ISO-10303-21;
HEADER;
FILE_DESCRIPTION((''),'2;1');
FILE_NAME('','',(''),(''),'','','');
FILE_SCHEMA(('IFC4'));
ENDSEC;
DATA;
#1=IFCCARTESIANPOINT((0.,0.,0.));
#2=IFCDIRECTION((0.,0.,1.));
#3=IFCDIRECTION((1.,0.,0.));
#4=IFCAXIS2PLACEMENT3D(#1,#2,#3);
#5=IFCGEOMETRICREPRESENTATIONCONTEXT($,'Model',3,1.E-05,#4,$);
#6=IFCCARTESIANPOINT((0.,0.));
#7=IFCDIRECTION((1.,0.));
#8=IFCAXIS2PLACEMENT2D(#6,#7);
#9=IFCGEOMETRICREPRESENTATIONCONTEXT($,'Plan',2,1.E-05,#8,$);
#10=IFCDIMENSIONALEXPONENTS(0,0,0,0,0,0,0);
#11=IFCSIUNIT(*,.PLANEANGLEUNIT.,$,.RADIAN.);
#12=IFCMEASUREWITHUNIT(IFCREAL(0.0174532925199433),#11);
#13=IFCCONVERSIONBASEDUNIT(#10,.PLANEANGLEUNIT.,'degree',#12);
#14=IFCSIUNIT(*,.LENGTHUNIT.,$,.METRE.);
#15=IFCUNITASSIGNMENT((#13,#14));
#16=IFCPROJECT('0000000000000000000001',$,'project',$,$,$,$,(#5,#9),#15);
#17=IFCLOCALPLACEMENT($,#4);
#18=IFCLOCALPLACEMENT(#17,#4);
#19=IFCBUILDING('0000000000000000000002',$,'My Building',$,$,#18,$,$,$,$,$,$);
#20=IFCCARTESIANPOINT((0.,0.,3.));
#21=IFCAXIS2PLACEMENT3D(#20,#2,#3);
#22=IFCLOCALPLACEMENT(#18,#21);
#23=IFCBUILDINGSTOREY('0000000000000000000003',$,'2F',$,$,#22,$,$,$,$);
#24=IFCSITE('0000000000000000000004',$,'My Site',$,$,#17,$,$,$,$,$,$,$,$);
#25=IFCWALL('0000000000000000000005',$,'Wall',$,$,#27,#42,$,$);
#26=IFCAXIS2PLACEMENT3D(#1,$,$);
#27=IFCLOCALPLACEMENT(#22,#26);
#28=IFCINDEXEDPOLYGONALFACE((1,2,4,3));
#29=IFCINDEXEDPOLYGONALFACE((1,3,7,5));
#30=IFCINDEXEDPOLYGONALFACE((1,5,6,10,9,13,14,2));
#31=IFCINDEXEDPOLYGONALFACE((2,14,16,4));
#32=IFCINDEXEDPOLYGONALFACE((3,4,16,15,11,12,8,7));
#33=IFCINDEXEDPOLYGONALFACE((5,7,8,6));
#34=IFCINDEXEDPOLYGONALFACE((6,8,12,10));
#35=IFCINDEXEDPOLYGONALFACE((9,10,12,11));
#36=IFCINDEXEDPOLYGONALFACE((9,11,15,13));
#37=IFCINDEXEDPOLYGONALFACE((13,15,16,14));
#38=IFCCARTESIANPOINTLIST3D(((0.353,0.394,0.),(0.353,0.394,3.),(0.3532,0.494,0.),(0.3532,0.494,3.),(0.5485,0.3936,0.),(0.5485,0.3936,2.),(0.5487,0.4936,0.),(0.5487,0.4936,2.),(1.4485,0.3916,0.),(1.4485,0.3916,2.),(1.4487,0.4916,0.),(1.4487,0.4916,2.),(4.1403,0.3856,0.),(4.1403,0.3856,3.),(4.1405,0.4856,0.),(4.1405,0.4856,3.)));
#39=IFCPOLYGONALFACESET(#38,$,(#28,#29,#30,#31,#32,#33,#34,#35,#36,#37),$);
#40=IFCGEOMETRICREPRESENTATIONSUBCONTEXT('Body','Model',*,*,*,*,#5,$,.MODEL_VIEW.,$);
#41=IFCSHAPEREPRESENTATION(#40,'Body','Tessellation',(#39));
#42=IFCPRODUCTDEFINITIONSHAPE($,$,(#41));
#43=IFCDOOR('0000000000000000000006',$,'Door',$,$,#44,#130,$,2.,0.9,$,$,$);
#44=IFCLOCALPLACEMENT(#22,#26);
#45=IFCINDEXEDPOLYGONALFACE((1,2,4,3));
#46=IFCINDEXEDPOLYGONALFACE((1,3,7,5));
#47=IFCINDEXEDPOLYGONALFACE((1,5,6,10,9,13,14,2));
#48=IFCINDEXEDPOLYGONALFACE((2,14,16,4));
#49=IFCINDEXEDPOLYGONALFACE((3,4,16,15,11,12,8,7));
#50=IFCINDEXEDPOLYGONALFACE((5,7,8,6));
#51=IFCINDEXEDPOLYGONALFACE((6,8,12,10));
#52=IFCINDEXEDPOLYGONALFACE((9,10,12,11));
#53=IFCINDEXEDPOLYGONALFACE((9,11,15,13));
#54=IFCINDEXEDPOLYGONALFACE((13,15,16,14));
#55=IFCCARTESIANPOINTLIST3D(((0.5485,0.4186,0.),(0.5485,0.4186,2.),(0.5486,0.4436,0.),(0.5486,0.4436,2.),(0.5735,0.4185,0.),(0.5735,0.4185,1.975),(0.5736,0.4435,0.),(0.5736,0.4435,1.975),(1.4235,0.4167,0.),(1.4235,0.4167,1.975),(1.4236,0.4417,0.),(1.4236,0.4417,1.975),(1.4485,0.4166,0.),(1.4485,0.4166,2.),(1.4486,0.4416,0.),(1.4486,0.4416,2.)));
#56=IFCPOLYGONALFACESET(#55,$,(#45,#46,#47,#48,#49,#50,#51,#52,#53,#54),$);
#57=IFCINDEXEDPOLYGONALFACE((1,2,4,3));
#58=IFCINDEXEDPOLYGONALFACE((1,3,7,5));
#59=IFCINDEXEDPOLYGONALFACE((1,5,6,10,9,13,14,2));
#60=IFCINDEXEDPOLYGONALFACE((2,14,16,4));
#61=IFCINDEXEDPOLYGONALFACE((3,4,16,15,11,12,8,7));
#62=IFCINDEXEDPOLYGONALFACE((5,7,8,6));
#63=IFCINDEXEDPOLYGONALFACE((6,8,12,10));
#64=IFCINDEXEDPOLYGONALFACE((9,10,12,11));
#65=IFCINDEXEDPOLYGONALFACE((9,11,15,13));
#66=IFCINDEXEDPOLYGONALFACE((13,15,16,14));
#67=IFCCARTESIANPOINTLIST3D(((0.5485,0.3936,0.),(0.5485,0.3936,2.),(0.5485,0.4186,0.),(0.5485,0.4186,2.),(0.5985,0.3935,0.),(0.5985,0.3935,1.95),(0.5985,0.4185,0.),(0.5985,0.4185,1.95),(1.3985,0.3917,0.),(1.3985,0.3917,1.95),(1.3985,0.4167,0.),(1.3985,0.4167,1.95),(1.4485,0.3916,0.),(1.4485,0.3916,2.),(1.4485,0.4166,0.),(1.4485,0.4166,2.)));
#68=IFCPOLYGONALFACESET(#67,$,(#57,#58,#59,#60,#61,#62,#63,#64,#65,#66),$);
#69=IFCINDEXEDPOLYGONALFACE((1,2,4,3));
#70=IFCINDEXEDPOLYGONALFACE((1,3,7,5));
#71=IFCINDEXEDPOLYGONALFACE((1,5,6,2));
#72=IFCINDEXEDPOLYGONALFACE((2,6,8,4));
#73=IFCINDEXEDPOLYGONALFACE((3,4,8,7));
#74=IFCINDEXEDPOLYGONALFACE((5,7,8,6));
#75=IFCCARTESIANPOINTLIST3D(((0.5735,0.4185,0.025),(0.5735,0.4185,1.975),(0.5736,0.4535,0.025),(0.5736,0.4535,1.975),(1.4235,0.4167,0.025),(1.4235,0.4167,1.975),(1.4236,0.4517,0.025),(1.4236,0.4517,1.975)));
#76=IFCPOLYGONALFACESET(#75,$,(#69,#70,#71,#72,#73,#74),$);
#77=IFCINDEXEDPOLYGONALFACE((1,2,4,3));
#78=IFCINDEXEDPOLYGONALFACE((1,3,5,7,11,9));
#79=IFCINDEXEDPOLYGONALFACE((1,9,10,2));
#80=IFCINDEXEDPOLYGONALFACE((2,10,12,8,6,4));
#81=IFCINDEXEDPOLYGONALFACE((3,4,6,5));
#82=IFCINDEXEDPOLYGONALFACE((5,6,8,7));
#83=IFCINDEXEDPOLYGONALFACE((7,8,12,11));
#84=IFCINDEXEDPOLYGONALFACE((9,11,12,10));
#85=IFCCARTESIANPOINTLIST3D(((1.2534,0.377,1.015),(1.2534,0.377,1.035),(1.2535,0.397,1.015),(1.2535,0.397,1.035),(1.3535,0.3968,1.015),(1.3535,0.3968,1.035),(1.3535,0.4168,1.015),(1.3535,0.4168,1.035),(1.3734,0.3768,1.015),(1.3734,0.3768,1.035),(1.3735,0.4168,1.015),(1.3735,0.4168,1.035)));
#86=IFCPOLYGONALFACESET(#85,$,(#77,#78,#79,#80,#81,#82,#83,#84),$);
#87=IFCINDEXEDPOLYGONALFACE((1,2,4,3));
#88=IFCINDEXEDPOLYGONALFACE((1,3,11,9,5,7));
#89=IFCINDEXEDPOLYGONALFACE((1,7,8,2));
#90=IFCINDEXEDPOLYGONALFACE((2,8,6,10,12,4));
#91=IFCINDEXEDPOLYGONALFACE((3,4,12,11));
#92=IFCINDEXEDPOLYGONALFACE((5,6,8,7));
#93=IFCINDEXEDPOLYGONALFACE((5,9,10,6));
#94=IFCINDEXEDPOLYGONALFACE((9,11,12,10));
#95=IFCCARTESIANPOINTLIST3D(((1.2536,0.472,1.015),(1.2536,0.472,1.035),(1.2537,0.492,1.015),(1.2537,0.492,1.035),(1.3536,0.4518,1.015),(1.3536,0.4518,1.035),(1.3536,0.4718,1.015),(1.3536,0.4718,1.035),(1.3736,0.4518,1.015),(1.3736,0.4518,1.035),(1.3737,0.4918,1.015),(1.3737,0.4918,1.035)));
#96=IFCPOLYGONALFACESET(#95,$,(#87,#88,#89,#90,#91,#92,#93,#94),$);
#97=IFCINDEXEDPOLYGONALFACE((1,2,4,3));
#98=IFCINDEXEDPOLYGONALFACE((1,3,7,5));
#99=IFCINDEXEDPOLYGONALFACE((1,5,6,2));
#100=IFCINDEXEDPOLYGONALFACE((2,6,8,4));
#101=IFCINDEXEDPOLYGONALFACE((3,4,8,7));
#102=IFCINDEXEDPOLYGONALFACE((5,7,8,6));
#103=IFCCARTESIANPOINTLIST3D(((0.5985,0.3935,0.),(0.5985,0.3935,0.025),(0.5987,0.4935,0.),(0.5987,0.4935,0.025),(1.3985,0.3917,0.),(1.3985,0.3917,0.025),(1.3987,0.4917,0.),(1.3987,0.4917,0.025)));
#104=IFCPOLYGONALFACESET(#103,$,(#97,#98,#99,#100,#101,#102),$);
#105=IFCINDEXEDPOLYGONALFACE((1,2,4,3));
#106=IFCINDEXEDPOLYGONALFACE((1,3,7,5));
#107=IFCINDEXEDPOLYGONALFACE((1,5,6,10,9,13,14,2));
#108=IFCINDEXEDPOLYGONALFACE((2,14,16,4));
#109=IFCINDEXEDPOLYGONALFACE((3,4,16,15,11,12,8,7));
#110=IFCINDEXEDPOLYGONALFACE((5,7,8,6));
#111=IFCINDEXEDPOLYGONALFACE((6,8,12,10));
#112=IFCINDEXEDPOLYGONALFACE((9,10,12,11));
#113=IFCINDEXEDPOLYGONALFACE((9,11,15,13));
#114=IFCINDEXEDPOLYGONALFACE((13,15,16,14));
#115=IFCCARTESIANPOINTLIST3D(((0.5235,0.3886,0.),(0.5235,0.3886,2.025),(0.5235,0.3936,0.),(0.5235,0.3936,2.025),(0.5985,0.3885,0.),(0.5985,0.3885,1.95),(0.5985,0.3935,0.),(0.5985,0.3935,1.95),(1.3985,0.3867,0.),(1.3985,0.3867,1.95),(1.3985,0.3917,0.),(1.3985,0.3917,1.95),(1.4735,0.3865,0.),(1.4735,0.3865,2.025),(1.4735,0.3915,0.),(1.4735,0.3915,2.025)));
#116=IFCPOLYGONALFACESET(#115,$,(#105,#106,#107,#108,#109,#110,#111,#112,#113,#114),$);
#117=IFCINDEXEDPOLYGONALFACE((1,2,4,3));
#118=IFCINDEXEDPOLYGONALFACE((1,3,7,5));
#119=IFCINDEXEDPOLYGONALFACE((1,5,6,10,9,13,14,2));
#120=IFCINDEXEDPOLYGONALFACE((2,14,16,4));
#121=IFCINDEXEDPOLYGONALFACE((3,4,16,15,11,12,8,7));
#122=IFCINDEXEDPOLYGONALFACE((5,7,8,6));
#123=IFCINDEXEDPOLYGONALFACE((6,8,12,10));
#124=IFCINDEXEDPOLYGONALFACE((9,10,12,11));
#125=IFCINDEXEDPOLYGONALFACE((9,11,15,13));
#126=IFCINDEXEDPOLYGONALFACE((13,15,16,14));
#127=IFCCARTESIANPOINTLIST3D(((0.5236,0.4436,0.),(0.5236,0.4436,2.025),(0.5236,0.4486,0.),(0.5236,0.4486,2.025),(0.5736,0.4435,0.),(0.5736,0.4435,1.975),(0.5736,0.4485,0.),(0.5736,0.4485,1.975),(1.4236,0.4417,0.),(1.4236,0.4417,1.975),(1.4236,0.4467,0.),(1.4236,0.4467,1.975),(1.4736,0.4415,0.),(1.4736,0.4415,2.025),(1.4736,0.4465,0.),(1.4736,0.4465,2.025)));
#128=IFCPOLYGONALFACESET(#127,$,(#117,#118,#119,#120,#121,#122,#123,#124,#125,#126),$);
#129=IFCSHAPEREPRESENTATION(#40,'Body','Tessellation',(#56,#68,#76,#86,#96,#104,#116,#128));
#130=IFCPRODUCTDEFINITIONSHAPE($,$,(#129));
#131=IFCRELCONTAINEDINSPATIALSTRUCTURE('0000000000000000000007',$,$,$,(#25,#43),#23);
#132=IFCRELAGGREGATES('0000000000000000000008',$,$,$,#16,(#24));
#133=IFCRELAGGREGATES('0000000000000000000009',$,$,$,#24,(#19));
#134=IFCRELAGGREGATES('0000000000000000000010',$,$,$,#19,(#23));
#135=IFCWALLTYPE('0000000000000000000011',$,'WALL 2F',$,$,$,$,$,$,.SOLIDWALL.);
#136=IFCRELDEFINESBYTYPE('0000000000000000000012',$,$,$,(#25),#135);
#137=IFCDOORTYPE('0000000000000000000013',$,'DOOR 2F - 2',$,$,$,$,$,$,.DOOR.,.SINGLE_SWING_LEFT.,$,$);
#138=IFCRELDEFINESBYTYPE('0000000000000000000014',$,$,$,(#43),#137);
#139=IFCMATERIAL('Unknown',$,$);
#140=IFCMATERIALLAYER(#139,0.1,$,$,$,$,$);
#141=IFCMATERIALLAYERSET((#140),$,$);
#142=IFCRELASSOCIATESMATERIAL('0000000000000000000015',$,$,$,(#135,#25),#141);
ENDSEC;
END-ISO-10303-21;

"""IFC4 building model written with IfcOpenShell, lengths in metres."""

from ifc_helpers import new_model, entity, si_unit, converted_unit, frame, origin_with_axes, origin_2d_with_axis, place, context, subcontext, project, spatial, line, indexed_curve, outline, extrude, shape, source, transform, mapped, material, layer, layer_set, layer_usage, type_object, type_shapes, element, fill, save


model = new_model("IFC4")

# Units and contexts
model_context = context("Model", 3, precision=1e-05, world=origin_with_axes())
plan_context = context("Plan", 2, precision=1e-05, world=origin_2d_with_axis())
body_context_1 = subcontext(model_context, "Body", "Model", "MODEL_VIEW")
body_context_2 = subcontext(plan_context, "Body", "Plan", "PLAN_VIEW")
ifc_project = project(units=[converted_unit("PLANEANGLEUNIT", "degree", entity("IfcReal", 0.0174532925199433), si_unit("PLANEANGLEUNIT", "RADIAN"), dimensions=[0, 0, 0, 0, 0, 0, 0]), si_unit("LENGTHUNIT", "METRE")], contexts=[model_context, plan_context])

# Site, building, storey
site_placement = place(None, origin_with_axes())
site = spatial("IfcSite", under=ifc_project, at=site_placement, Name="My Site")
building_placement = place(site_placement, origin_with_axes())
building = spatial("IfcBuilding", under=site, at=building_placement, Name="My Building")
storey_placement = place(building_placement, frame((0.0, 0.0, 3.0), z_axis=(0.0, 0.0, 1.0), x_axis=(1.0, 0.0, 0.0)))
storey = spatial("IfcBuildingStorey", under=building, at=storey_placement, Name="2F")

# Shared definitions
ifc_material = material(Name="Unknown")
ifc_layer = layer(ifc_material, 0.1)
ifc_layer_set = layer_set([ifc_layer])
wall_type = type_object("IfcWallType", Name="WALL 2F", PredefinedType="SOLIDWALL", material=ifc_layer_set)

# Wall, opening, door
shared_shape_1 = source(origin_with_axes(), body_context_1, "Body", "SweptSolid", [
    extrude(outline(indexed_curve([(0.0, 0.0), (0.9, 0.0), (0.9, 2.0), (0.0, 2.0)], segments=[line(1, 2, 3, 4, 1)])), frame((0.0, -0.6, 0.0), z_axis=(0.0, -1.0, 0.0), x_axis=(1.0, 0.0, 0.0)), (0.0, 0.0, -1.0), 1.2),
])
door_type_1 = type_object("IfcDoorType", Name="DOOR 2F - 2", OperationType="SINGLE_SWING_LEFT", PredefinedType="DOOR")
shared_shape_2 = source(origin_with_axes(), body_context_1, "Body", "SweptSolid", [
    extrude(outline(indexed_curve([(0.0, 0.0), (0.0, 2.0), (0.9, 2.0), (0.9, 0.0), (0.875, 0.0), (0.875, 1.975), (0.025, 1.975), (0.025, 0.0)], segments=[line(1, 2, 3, 4, 5, 6, 7, 8, 1)])), frame((0.0, 0.025, 0.0), z_axis=(0.0, -1.0, 0.0), x_axis=(1.0, 0.0, 0.0)), (0.0, 0.0, -1.0), 0.025),
    extrude(outline(indexed_curve([(0.0, 0.0), (0.0, 2.0), (0.9, 2.0), (0.9, 0.0), (0.85, 0.0), (0.85, 1.95), (0.05, 1.95), (0.05, 0.0)], segments=[line(1, 2, 3, 4, 5, 6, 7, 8, 1)])), frame((0.0, 0.0, 0.0), z_axis=(0.0, -1.0, 0.0), x_axis=(1.0, 0.0, 0.0)), (0.0, 0.0, -1.0), 0.025),
    extrude(outline(indexed_curve([(0.0, 0.0), (0.85, 0.0), (0.85, 0.035), (0.0, 0.035)], segments=[line(1, 2, 3, 4, 1)])), frame((0.025, 0.025, 0.025), z_axis=(0.0, 0.0, 1.0), x_axis=(1.0, 0.0, 0.0)), (0.0, 0.0, 1.0), 1.95),
    extrude(outline(indexed_curve([(0.0, 0.0), (0.0, -0.04), (-0.12, -0.04), (-0.12, -0.02), (-0.02, -0.02), (-0.02, 0.0)], segments=[line(1, 2, 3, 4, 5, 6, 1)])), frame((0.825, 0.025, 1.015), z_axis=(0.0, 0.0, 1.0), x_axis=(1.0, 0.0, 0.0)), (0.0, 0.0, 1.0), 0.02),
    extrude(outline(indexed_curve([(0.0, 0.0), (0.0, 0.04), (-0.12, 0.04), (-0.12, 0.02), (-0.02, 0.02), (-0.02, 0.0)], segments=[line(1, 2, 3, 4, 5, 6, 1)])), frame((0.825, 0.06, 1.015), z_axis=(0.0, 0.0, 1.0), x_axis=(1.0, 0.0, 0.0)), (0.0, 0.0, 1.0), 0.02),
    extrude(outline(indexed_curve([(0.0, 0.0), (0.8, 0.0), (0.8, 0.1), (0.0, 0.1)], segments=[line(1, 2, 3, 4, 1)])), frame((0.05, 0.0, 0.0), z_axis=(0.0, 0.0, 1.0), x_axis=(1.0, 0.0, 0.0)), (0.0, 0.0, 1.0), 0.025),
    extrude(outline(indexed_curve([(0.0, 0.0), (0.0, 2.025), (0.95, 2.025), (0.95, 0.0), (0.875, 0.0), (0.875, 1.95), (0.075, 1.95), (0.075, 0.0)], segments=[line(1, 2, 3, 4, 5, 6, 7, 8, 1)])), frame((-0.025, -0.005, 0.0), z_axis=(0.0, -1.0, 0.0), x_axis=(1.0, 0.0, 0.0)), (0.0, 0.0, -1.0), 0.005),
    extrude(outline(indexed_curve([(0.0, 0.0), (0.0, 2.025), (0.95, 2.025), (0.95, 0.0), (0.9, 0.0), (0.9, 1.975), (0.05, 1.975), (0.05, 0.0)], segments=[line(1, 2, 3, 4, 5, 6, 7, 8, 1)])), frame((-0.025, 0.05, 0.0), z_axis=(0.0, -1.0, 0.0), x_axis=(1.0, 0.0, 0.0)), (0.0, 0.0, -1.0), 0.005),
])
shared_shape_3 = source(origin_with_axes(), body_context_2, "Body", "Curve2D", [
    entity("IfcIndexedPolyCurve", entity("IfcCartesianPointList2D", [[0.0, 0.0], [0.0, 0.05], [0.025, 0.05], [0.025, 0.025], [0.05, 0.025], [0.05, 0.0]]), [entity("IfcLineIndex", [1, 2, 3, 4, 5, 6, 1])]),
    entity("IfcIndexedPolyCurve", entity("IfcCartesianPointList2D", [[0.9, 0.0], [0.9, 0.05], [0.875, 0.05], [0.875, 0.025], [0.85, 0.025], [0.85, 0.0]]), [entity("IfcLineIndex", [1, 2, 3, 4, 5, 6, 1])]),
    entity("IfcTrimmedCurve", entity("IfcEllipse", entity("IfcAxis2Placement2D", entity("IfcCartesianPoint", [0.06, 0.05]), entity("IfcDirection", [1.0, 0.0])), 0.815, 0.85), [entity("IfcCartesianPoint", [0.875, 0.05])], [entity("IfcCartesianPoint", [0.06, 0.9])], True, "CARTESIAN"),
    entity("IfcIndexedPolyCurve", entity("IfcCartesianPointList2D", [[0.025, 0.05], [0.06, 0.05], [0.06, 0.9], [0.025, 0.9]]), [entity("IfcLineIndex", [1, 2, 3, 4, 1])]),
])
type_shapes(door_type_1, [shared_shape_2, shared_shape_3])
ifc_layer_usage_1 = layer_usage(ifc_layer_set, "AXIS2", "POSITIVE", 0.0)
wall_1_placement = place(storey_placement, frame((0.353, 0.394, 0.0), z_axis=(0.0, 0.0, 1.0), x_axis=(0.999998, -0.002218, 0.0)))
wall_1 = element("IfcWall", 1, at=wall_1_placement, inside=storey, type_object=wall_type, material=ifc_layer_usage_1, Name="Wall", context=body_context_1, shape_type="SweptSolid", body=[
    extrude(outline(indexed_curve([(0.0, 0.0), (0.0, 0.1), (3.7873, 0.1), (3.7873, 0.0)], segments=[line(1, 2, 3, 4, 1)])), origin_with_axes(), (0.0, 0.0, 1.0), 3.0),
])
opening_1_placement = place(wall_1_placement, frame((0.1955, 0.0, 0.0), z_axis=(0.0, 0.0, 1.0), x_axis=(1.0, 0.0, 0.0)))
opening_1 = element("IfcOpeningElement", 2, at=opening_1_placement, cuts=wall_1, PredefinedType="OPENING", context=body_context_1, shape_type="MappedRepresentation", body=[
    mapped(shared_shape_1, transform((0.0, 0.0, 0.0), x_axis=(1.0, 0.0, 0.0), y_axis=(0.0, 1.0, 0.0), z_axis=(0.0, 0.0, 1.0), scale=1.0)),
])
door_1_placement = place(opening_1_placement, origin_with_axes())
door_1 = element("IfcDoor", 3, at=door_1_placement, inside=storey, type_object=door_type_1, Name="Door", OverallHeight=2.0, OverallWidth=0.9, shapes=[
    shape(body_context_1, "Body", "MappedRepresentation", [mapped(shared_shape_2, transform((0.0, 0.0, 0.0), x_axis=(1.0, 0.0, 0.0), y_axis=(0.0, 1.0, 0.0), z_axis=(0.0, 0.0, 1.0), scale=1.0))]),
    shape(body_context_2, "Body", "MappedRepresentation", [mapped(shared_shape_3, transform((0.0, 0.0, 0.0), x_axis=(1.0, 0.0, 0.0), y_axis=(0.0, 1.0, 0.0), z_axis=(0.0, 0.0, 1.0), scale=1.0))]),
])
fill(opening_1, door_1)

save(model, "model.ifc")
